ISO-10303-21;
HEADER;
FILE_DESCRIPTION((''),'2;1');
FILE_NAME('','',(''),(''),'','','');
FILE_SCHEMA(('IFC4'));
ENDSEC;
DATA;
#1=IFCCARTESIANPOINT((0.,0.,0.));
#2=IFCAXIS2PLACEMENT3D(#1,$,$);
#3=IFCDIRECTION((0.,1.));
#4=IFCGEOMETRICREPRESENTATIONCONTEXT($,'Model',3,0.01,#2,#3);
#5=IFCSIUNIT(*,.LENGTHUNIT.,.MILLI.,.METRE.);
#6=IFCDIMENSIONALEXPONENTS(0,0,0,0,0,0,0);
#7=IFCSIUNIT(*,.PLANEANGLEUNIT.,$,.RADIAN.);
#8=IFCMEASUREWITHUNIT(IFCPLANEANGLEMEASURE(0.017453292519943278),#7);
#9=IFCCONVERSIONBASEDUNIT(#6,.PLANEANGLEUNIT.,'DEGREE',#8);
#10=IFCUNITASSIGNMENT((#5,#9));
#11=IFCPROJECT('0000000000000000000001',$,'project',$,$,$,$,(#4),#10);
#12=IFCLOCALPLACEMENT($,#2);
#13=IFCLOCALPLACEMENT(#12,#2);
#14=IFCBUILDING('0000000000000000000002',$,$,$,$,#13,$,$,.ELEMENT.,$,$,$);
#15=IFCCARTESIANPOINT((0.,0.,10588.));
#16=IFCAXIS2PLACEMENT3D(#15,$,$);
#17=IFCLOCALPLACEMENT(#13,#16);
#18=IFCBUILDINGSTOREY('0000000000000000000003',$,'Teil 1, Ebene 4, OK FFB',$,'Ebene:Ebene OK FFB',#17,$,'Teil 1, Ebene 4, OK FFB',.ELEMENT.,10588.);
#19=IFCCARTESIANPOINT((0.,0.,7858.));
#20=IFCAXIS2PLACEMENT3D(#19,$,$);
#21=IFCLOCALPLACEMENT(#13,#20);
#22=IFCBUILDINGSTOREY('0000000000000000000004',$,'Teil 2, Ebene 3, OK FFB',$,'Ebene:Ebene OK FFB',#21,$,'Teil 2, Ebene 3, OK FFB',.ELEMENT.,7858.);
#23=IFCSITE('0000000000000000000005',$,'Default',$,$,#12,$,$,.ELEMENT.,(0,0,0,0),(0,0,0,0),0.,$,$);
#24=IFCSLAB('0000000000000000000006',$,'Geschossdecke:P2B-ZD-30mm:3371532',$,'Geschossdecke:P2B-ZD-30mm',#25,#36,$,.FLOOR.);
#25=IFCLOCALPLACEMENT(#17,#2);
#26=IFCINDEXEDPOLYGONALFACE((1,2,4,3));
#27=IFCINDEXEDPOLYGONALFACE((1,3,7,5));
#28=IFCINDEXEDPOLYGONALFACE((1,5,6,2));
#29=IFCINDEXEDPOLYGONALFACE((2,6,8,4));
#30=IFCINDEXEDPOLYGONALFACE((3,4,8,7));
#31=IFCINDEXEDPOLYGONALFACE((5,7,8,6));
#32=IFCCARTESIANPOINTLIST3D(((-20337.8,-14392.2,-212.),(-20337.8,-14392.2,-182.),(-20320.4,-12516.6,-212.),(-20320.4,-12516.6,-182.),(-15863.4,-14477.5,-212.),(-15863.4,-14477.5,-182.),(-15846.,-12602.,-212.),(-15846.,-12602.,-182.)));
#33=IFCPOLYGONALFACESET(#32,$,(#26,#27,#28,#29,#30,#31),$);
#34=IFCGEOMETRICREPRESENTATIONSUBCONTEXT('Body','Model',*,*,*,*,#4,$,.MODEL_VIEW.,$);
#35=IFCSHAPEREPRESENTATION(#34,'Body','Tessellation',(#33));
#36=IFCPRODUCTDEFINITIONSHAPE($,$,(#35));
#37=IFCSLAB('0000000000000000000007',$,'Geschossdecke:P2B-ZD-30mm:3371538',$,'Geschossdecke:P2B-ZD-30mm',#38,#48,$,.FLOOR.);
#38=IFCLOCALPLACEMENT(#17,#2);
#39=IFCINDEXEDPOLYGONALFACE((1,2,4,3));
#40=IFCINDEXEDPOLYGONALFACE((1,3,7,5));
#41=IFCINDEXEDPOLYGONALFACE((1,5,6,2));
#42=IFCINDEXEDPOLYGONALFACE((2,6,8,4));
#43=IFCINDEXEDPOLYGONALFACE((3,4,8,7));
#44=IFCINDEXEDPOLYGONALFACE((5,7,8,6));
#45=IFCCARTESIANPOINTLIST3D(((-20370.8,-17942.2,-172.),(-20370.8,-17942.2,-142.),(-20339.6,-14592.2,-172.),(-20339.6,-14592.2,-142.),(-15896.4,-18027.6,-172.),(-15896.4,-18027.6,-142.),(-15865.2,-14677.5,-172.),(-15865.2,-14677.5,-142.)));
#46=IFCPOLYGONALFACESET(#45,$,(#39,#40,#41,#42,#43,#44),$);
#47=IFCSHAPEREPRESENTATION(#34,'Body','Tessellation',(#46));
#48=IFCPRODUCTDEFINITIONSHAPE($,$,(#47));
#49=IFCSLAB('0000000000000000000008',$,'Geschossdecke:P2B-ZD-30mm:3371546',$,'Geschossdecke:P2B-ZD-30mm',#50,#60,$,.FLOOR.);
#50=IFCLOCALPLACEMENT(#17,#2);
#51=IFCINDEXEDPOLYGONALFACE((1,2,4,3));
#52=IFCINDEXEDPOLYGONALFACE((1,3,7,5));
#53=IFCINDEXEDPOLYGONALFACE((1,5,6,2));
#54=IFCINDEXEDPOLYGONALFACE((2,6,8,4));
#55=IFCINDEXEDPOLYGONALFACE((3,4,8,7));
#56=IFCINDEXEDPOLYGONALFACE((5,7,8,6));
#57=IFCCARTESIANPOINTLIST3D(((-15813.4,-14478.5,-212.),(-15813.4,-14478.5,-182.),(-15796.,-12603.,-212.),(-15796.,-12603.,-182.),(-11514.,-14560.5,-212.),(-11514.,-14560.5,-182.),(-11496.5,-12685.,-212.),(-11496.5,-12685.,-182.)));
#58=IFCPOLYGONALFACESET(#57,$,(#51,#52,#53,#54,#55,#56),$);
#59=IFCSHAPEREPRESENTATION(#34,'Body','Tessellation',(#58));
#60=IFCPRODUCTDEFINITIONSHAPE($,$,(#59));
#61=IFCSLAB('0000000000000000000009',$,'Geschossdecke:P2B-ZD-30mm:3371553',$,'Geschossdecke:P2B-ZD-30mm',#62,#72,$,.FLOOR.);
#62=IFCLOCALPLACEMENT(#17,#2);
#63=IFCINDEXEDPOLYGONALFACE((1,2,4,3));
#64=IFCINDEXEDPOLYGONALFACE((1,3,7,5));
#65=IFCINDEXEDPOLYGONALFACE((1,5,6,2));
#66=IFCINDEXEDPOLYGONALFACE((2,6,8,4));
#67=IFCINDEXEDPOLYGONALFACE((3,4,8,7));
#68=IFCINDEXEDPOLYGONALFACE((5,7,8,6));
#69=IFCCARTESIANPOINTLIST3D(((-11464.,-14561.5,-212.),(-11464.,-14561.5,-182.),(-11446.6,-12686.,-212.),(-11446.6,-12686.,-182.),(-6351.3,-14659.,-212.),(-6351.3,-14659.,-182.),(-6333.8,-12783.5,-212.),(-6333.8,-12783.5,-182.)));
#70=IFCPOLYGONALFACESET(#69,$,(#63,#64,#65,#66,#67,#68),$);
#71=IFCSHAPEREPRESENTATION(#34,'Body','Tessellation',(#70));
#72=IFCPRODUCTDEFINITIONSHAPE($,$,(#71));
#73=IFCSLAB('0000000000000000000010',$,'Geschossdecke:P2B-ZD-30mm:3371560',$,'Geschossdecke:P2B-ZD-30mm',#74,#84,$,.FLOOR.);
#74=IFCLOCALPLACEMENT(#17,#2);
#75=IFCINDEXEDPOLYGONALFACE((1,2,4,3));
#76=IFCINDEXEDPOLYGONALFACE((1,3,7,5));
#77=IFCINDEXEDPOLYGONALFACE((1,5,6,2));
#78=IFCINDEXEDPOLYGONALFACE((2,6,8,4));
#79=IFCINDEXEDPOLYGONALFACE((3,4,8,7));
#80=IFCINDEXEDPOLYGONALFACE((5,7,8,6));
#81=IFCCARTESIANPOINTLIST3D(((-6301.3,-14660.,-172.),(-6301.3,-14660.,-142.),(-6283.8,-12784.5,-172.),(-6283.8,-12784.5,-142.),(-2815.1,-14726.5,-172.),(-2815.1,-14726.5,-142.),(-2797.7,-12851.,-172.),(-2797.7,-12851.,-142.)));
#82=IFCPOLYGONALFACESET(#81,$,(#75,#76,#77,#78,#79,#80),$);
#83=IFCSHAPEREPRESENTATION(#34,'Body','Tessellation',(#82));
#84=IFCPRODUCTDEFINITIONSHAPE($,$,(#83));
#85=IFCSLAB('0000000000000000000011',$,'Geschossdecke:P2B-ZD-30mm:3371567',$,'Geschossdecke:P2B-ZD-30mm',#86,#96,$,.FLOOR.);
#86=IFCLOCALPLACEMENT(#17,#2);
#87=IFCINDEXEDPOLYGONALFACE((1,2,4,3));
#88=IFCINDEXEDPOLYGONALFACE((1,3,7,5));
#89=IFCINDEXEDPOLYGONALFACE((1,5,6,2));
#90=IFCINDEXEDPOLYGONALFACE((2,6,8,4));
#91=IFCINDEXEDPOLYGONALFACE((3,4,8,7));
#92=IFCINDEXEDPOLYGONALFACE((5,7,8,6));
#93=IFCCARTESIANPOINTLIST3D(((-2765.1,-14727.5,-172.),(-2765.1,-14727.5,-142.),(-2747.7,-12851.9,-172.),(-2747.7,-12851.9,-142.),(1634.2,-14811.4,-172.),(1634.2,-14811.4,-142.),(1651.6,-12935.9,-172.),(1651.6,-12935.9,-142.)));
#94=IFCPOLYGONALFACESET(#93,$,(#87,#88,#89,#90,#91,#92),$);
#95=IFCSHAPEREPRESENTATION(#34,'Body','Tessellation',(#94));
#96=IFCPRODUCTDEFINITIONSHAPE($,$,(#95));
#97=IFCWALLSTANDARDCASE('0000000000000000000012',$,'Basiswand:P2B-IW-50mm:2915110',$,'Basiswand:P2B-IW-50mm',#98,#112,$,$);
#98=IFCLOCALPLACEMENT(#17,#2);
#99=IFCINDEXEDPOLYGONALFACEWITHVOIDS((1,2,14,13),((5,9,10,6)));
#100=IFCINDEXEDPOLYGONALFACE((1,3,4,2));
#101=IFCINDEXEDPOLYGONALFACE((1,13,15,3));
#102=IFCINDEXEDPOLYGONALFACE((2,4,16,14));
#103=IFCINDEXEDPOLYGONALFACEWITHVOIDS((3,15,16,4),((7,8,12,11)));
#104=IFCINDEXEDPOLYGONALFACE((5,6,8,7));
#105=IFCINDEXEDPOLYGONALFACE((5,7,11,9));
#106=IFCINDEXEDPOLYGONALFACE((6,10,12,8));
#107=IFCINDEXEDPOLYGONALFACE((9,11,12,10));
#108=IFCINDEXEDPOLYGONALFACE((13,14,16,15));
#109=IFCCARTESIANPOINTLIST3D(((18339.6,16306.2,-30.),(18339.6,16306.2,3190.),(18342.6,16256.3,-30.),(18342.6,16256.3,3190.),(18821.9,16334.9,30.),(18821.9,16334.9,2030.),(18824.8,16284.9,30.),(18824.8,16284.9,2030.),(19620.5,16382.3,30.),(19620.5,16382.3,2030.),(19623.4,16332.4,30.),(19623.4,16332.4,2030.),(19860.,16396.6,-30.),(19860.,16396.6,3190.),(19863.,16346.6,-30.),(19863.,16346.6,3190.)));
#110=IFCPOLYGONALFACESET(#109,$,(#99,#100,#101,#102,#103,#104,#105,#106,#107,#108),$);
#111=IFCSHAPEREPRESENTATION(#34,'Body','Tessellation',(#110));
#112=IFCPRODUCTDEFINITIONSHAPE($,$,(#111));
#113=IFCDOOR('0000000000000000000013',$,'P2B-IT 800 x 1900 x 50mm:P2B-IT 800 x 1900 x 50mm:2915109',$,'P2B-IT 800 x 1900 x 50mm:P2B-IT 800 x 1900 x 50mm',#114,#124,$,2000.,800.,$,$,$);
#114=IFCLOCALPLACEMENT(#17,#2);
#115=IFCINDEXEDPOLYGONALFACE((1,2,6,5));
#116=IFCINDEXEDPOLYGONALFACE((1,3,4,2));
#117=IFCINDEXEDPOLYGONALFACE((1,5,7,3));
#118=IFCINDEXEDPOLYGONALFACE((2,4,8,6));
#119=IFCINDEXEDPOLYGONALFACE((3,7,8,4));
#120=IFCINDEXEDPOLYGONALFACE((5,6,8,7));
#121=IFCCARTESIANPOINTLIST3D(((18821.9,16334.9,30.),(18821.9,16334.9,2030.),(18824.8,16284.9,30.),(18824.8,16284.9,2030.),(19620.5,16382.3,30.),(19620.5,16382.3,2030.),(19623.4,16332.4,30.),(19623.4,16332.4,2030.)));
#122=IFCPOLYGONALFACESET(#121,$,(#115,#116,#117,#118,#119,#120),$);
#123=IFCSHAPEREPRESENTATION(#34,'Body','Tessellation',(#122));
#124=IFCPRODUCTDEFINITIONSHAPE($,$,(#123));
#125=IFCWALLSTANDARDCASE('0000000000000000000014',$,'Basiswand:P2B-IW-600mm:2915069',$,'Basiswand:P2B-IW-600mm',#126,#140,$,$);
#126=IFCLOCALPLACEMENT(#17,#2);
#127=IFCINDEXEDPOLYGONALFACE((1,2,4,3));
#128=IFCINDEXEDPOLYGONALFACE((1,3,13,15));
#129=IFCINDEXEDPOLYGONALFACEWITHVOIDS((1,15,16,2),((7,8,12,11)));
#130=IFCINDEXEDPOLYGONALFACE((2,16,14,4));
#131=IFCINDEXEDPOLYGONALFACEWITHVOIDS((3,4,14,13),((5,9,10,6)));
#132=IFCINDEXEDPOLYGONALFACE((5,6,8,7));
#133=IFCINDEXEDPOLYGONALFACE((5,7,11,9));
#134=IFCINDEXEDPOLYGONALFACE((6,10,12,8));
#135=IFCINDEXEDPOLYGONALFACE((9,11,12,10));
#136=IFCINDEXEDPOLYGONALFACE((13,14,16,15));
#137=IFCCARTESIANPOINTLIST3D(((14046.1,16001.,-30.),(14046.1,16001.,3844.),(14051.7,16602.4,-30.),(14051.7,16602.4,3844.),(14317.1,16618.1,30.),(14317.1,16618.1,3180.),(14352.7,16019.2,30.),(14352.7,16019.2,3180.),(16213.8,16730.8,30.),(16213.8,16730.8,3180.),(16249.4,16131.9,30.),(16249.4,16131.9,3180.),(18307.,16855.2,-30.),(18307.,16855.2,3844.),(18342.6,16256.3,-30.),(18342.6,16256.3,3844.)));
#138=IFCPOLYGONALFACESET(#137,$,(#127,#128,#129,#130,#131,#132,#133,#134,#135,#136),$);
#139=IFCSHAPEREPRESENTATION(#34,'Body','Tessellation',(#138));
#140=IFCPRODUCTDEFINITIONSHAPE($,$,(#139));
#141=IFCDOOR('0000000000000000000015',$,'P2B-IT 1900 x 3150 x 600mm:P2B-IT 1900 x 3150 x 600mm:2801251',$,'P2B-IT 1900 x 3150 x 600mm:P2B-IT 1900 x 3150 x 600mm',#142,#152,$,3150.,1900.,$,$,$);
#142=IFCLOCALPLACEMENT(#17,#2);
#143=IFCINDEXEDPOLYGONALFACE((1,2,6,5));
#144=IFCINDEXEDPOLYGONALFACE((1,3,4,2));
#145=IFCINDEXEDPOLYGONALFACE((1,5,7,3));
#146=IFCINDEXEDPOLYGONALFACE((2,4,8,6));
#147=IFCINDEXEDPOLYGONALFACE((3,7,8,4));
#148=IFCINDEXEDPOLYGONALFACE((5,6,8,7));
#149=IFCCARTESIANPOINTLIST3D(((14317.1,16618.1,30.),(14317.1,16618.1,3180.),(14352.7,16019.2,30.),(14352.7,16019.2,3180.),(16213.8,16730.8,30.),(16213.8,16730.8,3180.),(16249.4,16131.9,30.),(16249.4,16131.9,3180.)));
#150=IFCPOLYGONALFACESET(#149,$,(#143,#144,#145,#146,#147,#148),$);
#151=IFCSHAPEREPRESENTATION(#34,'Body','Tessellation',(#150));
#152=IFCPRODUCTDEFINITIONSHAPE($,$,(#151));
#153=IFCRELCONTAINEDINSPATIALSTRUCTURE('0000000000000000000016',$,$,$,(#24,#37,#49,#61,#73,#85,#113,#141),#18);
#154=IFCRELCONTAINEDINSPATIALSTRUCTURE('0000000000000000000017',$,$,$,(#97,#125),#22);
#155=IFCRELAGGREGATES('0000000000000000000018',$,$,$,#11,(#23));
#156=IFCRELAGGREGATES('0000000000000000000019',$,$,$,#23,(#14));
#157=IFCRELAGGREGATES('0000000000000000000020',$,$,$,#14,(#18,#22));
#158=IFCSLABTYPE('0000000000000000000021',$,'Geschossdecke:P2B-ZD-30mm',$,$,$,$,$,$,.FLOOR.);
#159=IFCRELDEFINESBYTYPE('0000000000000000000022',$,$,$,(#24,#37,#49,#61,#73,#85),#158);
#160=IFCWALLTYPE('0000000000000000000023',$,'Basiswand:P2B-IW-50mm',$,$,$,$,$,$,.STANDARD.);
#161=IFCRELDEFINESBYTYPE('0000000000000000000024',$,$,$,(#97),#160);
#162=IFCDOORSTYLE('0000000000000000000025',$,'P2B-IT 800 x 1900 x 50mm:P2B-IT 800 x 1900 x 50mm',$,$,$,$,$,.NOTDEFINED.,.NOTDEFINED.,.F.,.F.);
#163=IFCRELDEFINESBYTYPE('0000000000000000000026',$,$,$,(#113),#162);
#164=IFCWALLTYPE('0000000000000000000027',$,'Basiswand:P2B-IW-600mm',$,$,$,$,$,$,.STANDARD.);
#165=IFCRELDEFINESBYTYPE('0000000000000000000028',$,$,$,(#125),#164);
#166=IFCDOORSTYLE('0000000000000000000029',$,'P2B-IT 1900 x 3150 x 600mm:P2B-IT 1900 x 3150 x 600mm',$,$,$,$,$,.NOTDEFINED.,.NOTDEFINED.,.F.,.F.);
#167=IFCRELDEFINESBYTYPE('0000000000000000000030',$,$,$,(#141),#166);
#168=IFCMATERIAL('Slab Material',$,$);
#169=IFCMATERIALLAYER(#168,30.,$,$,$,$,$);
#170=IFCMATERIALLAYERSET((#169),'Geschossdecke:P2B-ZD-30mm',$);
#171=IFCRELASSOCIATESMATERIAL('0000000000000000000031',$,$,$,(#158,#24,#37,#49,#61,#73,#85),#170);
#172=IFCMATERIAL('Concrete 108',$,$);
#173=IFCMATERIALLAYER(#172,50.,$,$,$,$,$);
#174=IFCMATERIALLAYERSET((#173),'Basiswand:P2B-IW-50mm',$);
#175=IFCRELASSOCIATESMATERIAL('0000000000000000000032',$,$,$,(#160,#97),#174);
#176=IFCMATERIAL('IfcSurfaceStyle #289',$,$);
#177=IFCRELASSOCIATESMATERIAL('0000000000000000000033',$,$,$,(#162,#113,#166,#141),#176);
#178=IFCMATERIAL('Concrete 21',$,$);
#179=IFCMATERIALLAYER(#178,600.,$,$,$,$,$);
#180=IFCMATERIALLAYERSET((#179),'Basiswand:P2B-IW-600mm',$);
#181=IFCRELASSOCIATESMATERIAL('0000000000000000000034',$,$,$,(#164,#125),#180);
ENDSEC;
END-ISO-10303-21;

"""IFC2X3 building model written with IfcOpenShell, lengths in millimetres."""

from ifc_helpers import new_model, entity, si_unit, converted_unit, direction, frame, frame_2d, origin, origin_2d_with_axis, place, context, subcontext, project, spatial, polyline, rectangle, outline, extrude, source, transform, mapped, material, layer, layer_set, layer_usage, type_object, type_shapes, element, fill, save


model = new_model("IFC2X3")

# Units and contexts
model_context = context("Model", 3, precision=0.01, world=origin(), true_north=direction((0.0, 1.0)))
body_context = subcontext(model_context, "Body", "Model", "MODEL_VIEW")
ifc_project = project(units=[si_unit("LENGTHUNIT", "METRE", prefix="MILLI"), converted_unit("PLANEANGLEUNIT", "DEGREE", entity("IfcPlaneAngleMeasure", 0.017453292519943278), si_unit("PLANEANGLEUNIT", "RADIAN"), dimensions=[0, 0, 0, 0, 0, 0, 0])], contexts=[model_context])

# Site, building, storey
site_placement = place(None, origin())
site = spatial("IfcSite", under=ifc_project, at=site_placement, Name="Default", CompositionType="ELEMENT", RefLatitude=(0, 0, 0, 0), RefLongitude=(0, 0, 0, 0), RefElevation=0.0)
building_placement = place(site_placement, origin())
building = spatial("IfcBuilding", under=site, at=building_placement, CompositionType="ELEMENT")
storey_1_placement = place(building_placement, frame((0.0, 0.0, 10588.0)))
storey_1 = spatial("IfcBuildingStorey", under=building, at=storey_1_placement, Name="Teil 1, Ebene 4, OK FFB", ObjectType="Ebene:Ebene OK FFB", LongName="Teil 1, Ebene 4, OK FFB", CompositionType="ELEMENT", Elevation=10588.0)

# Slabs
ifc_material_1 = material(Name="Slab Material")
ifc_layer_1 = layer(ifc_material_1, 30.0)
ifc_layer_set_1 = layer_set([ifc_layer_1], Name="Geschossdecke:P2B-ZD-30mm")
slab_type = type_object("IfcSlabType", Name="Geschossdecke:P2B-ZD-30mm", PredefinedType="FLOOR", material=ifc_layer_set_1)
ifc_layer_usage_1 = layer_usage(ifc_layer_set_1, "AXIS3", "POSITIVE", 0.0)
slab_1_placement = place(storey_1_placement, origin())
element("IfcSlab", 1, at=slab_1_placement, inside=storey_1, type_object=slab_type, material=ifc_layer_usage_1, Name="Geschossdecke:P2B-ZD-30mm:3371532", ObjectType="Geschossdecke:P2B-ZD-30mm", PredefinedType="FLOOR", context=body_context, shape_type="SweptSolid", body=[
    extrude(outline(polyline([(-2246.8, -937.8), (2228.4, -937.8), (2246.8, 937.8), (-2228.4, 937.8), (-2246.8, -937.8)])), frame((-18091.9, -13497.1, -182.0), z_axis=(0.0, 0.0, -1.0), x_axis=(0.999818, -0.019077, 0.0)), (0.0, 0.0, 1.0), 30.0),
])
ifc_layer_usage_2 = layer_usage(ifc_layer_set_1, "AXIS3", "POSITIVE", 0.0)
slab_2_placement = place(storey_1_placement, origin())
element("IfcSlab", 2, at=slab_2_placement, inside=storey_1, type_object=slab_type, material=ifc_layer_usage_2, Name="Geschossdecke:P2B-ZD-30mm:3371538", ObjectType="Geschossdecke:P2B-ZD-30mm", PredefinedType="FLOOR", context=body_context, shape_type="SweptSolid", body=[
    extrude(outline(polyline([(-2254.0, -1675.0), (2221.2, -1675.0), (2254.0, 1675.0), (-2221.2, 1675.0), (-2254.0, -1675.0)])), frame((-18118.0, -16309.9, -142.0), z_axis=(0.0, 0.0, -1.0), x_axis=(0.999818, -0.019077, 0.0)), (0.0, 0.0, 1.0), 30.0),
])
ifc_layer_usage_3 = layer_usage(ifc_layer_set_1, "AXIS3", "POSITIVE", 0.0)
slab_3_placement = place(storey_1_placement, origin())
element("IfcSlab", 3, at=slab_3_placement, inside=storey_1, type_object=slab_type, material=ifc_layer_usage_3, Name="Geschossdecke:P2B-ZD-30mm:3371546", ObjectType="Geschossdecke:P2B-ZD-30mm", PredefinedType="FLOOR", context=body_context, shape_type="SweptSolid", body=[
    extrude(outline(polyline([(-2159.3, -937.8), (2140.9, -937.8), (2159.3, 937.8), (-2140.9, 937.8), (-2159.3, -937.8)])), frame((-13655.0, -13581.7, -182.0), z_axis=(0.0, 0.0, -1.0), x_axis=(0.999818, -0.019077, 0.0)), (0.0, 0.0, 1.0), 30.0),
])
ifc_layer_usage_4 = layer_usage(ifc_layer_set_1, "AXIS3", "POSITIVE", 0.0)
slab_4_placement = place(storey_1_placement, origin())
element("IfcSlab", 4, at=slab_4_placement, inside=storey_1, type_object=slab_type, material=ifc_layer_usage_4, Name="Geschossdecke:P2B-ZD-30mm:3371553", ObjectType="Geschossdecke:P2B-ZD-30mm", PredefinedType="FLOOR", context=body_context, shape_type="SweptSolid", body=[
    extrude(outline(polyline([(-2566.0, -937.8), (2547.6, -937.8), (2566.0, 937.8), (-2547.6, 937.8), (-2566.0, -937.8)])), frame((-8898.9, -13672.5, -182.0), z_axis=(0.0, 0.0, -1.0), x_axis=(0.999818, -0.019077, 0.0)), (0.0, 0.0, 1.0), 30.0),
])
ifc_layer_usage_5 = layer_usage(ifc_layer_set_1, "AXIS3", "POSITIVE", 0.0)
slab_5_placement = place(storey_1_placement, origin())
element("IfcSlab", 5, at=slab_5_placement, inside=storey_1, type_object=slab_type, material=ifc_layer_usage_5, Name="Geschossdecke:P2B-ZD-30mm:3371560", ObjectType="Geschossdecke:P2B-ZD-30mm", PredefinedType="FLOOR", context=body_context, shape_type="SweptSolid", body=[
    extrude(outline(polyline([(-1752.6, -937.8), (1734.2, -937.8), (1752.6, 937.8), (-1734.2, 937.8), (-1752.6, -937.8)])), frame((-4549.5, -13755.5, -142.0), z_axis=(0.0, 0.0, -1.0), x_axis=(0.999818, -0.019077, 0.0)), (0.0, 0.0, 1.0), 30.0),
])
ifc_layer_usage_6 = layer_usage(ifc_layer_set_1, "AXIS3", "POSITIVE", 0.0)
slab_6_placement = place(storey_1_placement, origin())
element("IfcSlab", 6, at=slab_6_placement, inside=storey_1, type_object=slab_type, material=ifc_layer_usage_6, Name="Geschossdecke:P2B-ZD-30mm:3371567", ObjectType="Geschossdecke:P2B-ZD-30mm", PredefinedType="FLOOR", context=body_context, shape_type="SweptSolid", body=[
    extrude(outline(polyline([(-2209.3, -937.8), (2190.9, -937.8), (2209.3, 937.8), (-2190.9, 937.8), (-2209.3, -937.8)])), frame((-556.7, -13831.7, -142.0), z_axis=(0.0, 0.0, -1.0), x_axis=(0.999818, -0.019077, 0.0)), (0.0, 0.0, 1.0), 30.0),
])

# Shared definitions
storey_2_placement = place(building_placement, frame((0.0, 0.0, 7858.0)))
storey_2 = spatial("IfcBuildingStorey", under=building, at=storey_2_placement, Name="Teil 2, Ebene 3, OK FFB", ObjectType="Ebene:Ebene OK FFB", LongName="Teil 2, Ebene 3, OK FFB", CompositionType="ELEMENT", Elevation=7858.0)

# Wall, opening, door
ifc_material_2 = material(Name="Concrete 108")
ifc_layer_2 = layer(ifc_material_2, 50.0)
ifc_layer_set_2 = layer_set([ifc_layer_2], Name="Basiswand:P2B-IW-50mm")
ifc_layer_usage_7 = layer_usage(ifc_layer_set_2, "AXIS2", "POSITIVE", -25.0)
wall_type_1 = type_object("IfcWallType", Name="Basiswand:P2B-IW-50mm", PredefinedType="STANDARD", material=ifc_layer_set_2)
wall_1_placement = place(storey_2_placement, frame((19861.5, 16371.6, 2700.0), z_axis=(0.0, 0.0, 1.0), x_axis=(-0.998239, -0.059319, 0.0)))
wall_1 = element("IfcWallStandardCase", 7, at=wall_1_placement, inside=storey_2, type_object=wall_type_1, material=ifc_layer_usage_7, Name="Basiswand:P2B-IW-50mm:2915110", ObjectType="Basiswand:P2B-IW-50mm", context=body_context, shape_type="SweptSolid", body=[
    extrude(rectangle(XDim=1523.1, YDim=50.0, at=frame_2d((761.6, 0.0), x_axis=(-1.0, 0.0))), origin(), (0.0, 0.0, 1.0), 3220.0),
])
opening_1_placement = place(wall_1_placement, frame((20797.7, 15164.6, 30.0), z_axis=(0.0, 0.0, 1.0), x_axis=(-0.998239, 0.059319, 0.0)))
opening_1 = element("IfcOpeningElement", 8, at=opening_1_placement, cuts=wall_1, ObjectType="Opening", context=body_context, shape_type="SweptSolid", body=[
    extrude(rectangle(XDim=2000.0, YDim=800.0, at=frame_2d((0.0, 0.0), x_axis=(1.0, 0.0))), frame((19221.2, 16358.6, 1030.0), z_axis=(0.059319, -0.998239, 0.0), x_axis=(0.0, 0.0, -1.0)), (0.0, 0.0, 1.0), 50.0),
])
ifc_material_3 = material(Name="IfcSurfaceStyle #289")
door_style_1 = type_object("IfcDoorStyle", Name="P2B-IT 800 x 1900 x 50mm:P2B-IT 800 x 1900 x 50mm", ConstructionType="NOTDEFINED", OperationType="NOTDEFINED", ParameterTakesPrecedence=False, Sizeable=False, material=ifc_material_3)
shared_shape_1 = source(origin(), body_context, "Body", "SweptSolid", [
    extrude(rectangle(XDim=50.0, YDim=800.0, at=origin_2d_with_axis()), frame((400.0, 25.0, 0.0), z_axis=(0.0, 0.0, 1.0), x_axis=(0.0, 1.0, 0.0)), (0.0, 0.0, 1.0), 2000.0),
])
type_shapes(door_style_1, [shared_shape_1])
door_1_placement = place(opening_1_placement, frame((18824.8, 16284.9, 30.0), z_axis=(0.0, 0.0, 1.0), x_axis=(0.998239, 0.059319, 0.0)))
door_1 = element("IfcDoor", 9, at=door_1_placement, inside=storey_1, type_object=door_style_1, material=ifc_material_3, Name="P2B-IT 800 x 1900 x 50mm:P2B-IT 800 x 1900 x 50mm:2915109", ObjectType="P2B-IT 800 x 1900 x 50mm:P2B-IT 800 x 1900 x 50mm", OverallHeight=2000.0, OverallWidth=800.0, context=body_context, shape_type="MappedRepresentation", body=[
    mapped(shared_shape_1, transform((0.0, 0.0, 0.0), scale=1.0)),
])
fill(opening_1, door_1)

# Wall, opening, door
ifc_material_4 = material(Name="Concrete 21")
ifc_layer_3 = layer(ifc_material_4, 600.0)
ifc_layer_set_3 = layer_set([ifc_layer_3], Name="Basiswand:P2B-IW-600mm")
ifc_layer_usage_8 = layer_usage(ifc_layer_set_3, "AXIS2", "NEGATIVE", 300.0)
wall_type_2 = type_object("IfcWallType", Name="Basiswand:P2B-IW-600mm", PredefinedType="STANDARD", material=ifc_layer_set_3)
wall_2_placement = place(storey_2_placement, frame((18324.8, 16555.8, 2700.0), z_axis=(0.0, 0.0, 1.0), x_axis=(-0.998239, -0.059319, 0.0)))
wall_2 = element("IfcWallStandardCase", 10, at=wall_2_placement, inside=storey_2, type_object=wall_type_2, material=ifc_layer_usage_8, Name="Basiswand:P2B-IW-600mm:2915069", ObjectType="Basiswand:P2B-IW-600mm", context=body_context, shape_type="SweptSolid", body=[
    extrude(outline(polyline([(4262.8, -300.0), (4304.1, 300.0), (1563.8, 300.0), (913.8, 300.0), (0.0, 300.0), (0.0, 250.0), (0.0, -300.0), (4262.8, -300.0)])), origin(), (0.0, 0.0, 1.0), 3874.0),
])
opening_2_placement = place(wall_2_placement, frame((19274.6, 15439.6, 30.0), z_axis=(0.0, 0.0, 1.0), x_axis=(-0.998239, 0.059319, 0.0)))
opening_2 = element("IfcOpeningElement", 11, at=opening_2_placement, cuts=wall_2, ObjectType="Opening", context=body_context, shape_type="SweptSolid", body=[
    extrude(rectangle(XDim=3150.0, YDim=1900.0, at=frame_2d((0.0, 0.0), x_axis=(1.0, 0.0))), frame((15265.5, 16674.5, 1605.0), z_axis=(0.059319, -0.998239, 0.0), x_axis=(0.0, 0.0, -1.0)), (0.0, 0.0, 1.0), 600.0),
])
door_style_2 = type_object("IfcDoorStyle", Name="P2B-IT 1900 x 3150 x 600mm:P2B-IT 1900 x 3150 x 600mm", ConstructionType="NOTDEFINED", OperationType="NOTDEFINED", ParameterTakesPrecedence=False, Sizeable=False, material=ifc_material_3)
shared_shape_2 = source(origin(), body_context, "Body", "SweptSolid", [
    extrude(rectangle(XDim=600.0, YDim=1900.0, at=origin_2d_with_axis()), frame((950.0, -300.0, 0.0), z_axis=(0.0, 0.0, 1.0), x_axis=(0.0, 1.0, 0.0)), (0.0, 0.0, 1.0), 3150.0),
])
type_shapes(door_style_2, [shared_shape_2])
door_2_placement = place(opening_2_placement, frame((16249.4, 16131.9, 30.0), z_axis=(0.0, 0.0, 1.0), x_axis=(-0.998239, -0.059319, 0.0)))
door_2 = element("IfcDoor", 12, at=door_2_placement, inside=storey_1, type_object=door_style_2, material=ifc_material_3, Name="P2B-IT 1900 x 3150 x 600mm:P2B-IT 1900 x 3150 x 600mm:2801251", ObjectType="P2B-IT 1900 x 3150 x 600mm:P2B-IT 1900 x 3150 x 600mm", OverallHeight=3150.0, OverallWidth=1900.0, context=body_context, shape_type="MappedRepresentation", body=[
    mapped(shared_shape_2, transform((0.0, 0.0, 0.0), scale=1.0)),
])
fill(opening_2, door_2)

save(model, "model.ifc")
